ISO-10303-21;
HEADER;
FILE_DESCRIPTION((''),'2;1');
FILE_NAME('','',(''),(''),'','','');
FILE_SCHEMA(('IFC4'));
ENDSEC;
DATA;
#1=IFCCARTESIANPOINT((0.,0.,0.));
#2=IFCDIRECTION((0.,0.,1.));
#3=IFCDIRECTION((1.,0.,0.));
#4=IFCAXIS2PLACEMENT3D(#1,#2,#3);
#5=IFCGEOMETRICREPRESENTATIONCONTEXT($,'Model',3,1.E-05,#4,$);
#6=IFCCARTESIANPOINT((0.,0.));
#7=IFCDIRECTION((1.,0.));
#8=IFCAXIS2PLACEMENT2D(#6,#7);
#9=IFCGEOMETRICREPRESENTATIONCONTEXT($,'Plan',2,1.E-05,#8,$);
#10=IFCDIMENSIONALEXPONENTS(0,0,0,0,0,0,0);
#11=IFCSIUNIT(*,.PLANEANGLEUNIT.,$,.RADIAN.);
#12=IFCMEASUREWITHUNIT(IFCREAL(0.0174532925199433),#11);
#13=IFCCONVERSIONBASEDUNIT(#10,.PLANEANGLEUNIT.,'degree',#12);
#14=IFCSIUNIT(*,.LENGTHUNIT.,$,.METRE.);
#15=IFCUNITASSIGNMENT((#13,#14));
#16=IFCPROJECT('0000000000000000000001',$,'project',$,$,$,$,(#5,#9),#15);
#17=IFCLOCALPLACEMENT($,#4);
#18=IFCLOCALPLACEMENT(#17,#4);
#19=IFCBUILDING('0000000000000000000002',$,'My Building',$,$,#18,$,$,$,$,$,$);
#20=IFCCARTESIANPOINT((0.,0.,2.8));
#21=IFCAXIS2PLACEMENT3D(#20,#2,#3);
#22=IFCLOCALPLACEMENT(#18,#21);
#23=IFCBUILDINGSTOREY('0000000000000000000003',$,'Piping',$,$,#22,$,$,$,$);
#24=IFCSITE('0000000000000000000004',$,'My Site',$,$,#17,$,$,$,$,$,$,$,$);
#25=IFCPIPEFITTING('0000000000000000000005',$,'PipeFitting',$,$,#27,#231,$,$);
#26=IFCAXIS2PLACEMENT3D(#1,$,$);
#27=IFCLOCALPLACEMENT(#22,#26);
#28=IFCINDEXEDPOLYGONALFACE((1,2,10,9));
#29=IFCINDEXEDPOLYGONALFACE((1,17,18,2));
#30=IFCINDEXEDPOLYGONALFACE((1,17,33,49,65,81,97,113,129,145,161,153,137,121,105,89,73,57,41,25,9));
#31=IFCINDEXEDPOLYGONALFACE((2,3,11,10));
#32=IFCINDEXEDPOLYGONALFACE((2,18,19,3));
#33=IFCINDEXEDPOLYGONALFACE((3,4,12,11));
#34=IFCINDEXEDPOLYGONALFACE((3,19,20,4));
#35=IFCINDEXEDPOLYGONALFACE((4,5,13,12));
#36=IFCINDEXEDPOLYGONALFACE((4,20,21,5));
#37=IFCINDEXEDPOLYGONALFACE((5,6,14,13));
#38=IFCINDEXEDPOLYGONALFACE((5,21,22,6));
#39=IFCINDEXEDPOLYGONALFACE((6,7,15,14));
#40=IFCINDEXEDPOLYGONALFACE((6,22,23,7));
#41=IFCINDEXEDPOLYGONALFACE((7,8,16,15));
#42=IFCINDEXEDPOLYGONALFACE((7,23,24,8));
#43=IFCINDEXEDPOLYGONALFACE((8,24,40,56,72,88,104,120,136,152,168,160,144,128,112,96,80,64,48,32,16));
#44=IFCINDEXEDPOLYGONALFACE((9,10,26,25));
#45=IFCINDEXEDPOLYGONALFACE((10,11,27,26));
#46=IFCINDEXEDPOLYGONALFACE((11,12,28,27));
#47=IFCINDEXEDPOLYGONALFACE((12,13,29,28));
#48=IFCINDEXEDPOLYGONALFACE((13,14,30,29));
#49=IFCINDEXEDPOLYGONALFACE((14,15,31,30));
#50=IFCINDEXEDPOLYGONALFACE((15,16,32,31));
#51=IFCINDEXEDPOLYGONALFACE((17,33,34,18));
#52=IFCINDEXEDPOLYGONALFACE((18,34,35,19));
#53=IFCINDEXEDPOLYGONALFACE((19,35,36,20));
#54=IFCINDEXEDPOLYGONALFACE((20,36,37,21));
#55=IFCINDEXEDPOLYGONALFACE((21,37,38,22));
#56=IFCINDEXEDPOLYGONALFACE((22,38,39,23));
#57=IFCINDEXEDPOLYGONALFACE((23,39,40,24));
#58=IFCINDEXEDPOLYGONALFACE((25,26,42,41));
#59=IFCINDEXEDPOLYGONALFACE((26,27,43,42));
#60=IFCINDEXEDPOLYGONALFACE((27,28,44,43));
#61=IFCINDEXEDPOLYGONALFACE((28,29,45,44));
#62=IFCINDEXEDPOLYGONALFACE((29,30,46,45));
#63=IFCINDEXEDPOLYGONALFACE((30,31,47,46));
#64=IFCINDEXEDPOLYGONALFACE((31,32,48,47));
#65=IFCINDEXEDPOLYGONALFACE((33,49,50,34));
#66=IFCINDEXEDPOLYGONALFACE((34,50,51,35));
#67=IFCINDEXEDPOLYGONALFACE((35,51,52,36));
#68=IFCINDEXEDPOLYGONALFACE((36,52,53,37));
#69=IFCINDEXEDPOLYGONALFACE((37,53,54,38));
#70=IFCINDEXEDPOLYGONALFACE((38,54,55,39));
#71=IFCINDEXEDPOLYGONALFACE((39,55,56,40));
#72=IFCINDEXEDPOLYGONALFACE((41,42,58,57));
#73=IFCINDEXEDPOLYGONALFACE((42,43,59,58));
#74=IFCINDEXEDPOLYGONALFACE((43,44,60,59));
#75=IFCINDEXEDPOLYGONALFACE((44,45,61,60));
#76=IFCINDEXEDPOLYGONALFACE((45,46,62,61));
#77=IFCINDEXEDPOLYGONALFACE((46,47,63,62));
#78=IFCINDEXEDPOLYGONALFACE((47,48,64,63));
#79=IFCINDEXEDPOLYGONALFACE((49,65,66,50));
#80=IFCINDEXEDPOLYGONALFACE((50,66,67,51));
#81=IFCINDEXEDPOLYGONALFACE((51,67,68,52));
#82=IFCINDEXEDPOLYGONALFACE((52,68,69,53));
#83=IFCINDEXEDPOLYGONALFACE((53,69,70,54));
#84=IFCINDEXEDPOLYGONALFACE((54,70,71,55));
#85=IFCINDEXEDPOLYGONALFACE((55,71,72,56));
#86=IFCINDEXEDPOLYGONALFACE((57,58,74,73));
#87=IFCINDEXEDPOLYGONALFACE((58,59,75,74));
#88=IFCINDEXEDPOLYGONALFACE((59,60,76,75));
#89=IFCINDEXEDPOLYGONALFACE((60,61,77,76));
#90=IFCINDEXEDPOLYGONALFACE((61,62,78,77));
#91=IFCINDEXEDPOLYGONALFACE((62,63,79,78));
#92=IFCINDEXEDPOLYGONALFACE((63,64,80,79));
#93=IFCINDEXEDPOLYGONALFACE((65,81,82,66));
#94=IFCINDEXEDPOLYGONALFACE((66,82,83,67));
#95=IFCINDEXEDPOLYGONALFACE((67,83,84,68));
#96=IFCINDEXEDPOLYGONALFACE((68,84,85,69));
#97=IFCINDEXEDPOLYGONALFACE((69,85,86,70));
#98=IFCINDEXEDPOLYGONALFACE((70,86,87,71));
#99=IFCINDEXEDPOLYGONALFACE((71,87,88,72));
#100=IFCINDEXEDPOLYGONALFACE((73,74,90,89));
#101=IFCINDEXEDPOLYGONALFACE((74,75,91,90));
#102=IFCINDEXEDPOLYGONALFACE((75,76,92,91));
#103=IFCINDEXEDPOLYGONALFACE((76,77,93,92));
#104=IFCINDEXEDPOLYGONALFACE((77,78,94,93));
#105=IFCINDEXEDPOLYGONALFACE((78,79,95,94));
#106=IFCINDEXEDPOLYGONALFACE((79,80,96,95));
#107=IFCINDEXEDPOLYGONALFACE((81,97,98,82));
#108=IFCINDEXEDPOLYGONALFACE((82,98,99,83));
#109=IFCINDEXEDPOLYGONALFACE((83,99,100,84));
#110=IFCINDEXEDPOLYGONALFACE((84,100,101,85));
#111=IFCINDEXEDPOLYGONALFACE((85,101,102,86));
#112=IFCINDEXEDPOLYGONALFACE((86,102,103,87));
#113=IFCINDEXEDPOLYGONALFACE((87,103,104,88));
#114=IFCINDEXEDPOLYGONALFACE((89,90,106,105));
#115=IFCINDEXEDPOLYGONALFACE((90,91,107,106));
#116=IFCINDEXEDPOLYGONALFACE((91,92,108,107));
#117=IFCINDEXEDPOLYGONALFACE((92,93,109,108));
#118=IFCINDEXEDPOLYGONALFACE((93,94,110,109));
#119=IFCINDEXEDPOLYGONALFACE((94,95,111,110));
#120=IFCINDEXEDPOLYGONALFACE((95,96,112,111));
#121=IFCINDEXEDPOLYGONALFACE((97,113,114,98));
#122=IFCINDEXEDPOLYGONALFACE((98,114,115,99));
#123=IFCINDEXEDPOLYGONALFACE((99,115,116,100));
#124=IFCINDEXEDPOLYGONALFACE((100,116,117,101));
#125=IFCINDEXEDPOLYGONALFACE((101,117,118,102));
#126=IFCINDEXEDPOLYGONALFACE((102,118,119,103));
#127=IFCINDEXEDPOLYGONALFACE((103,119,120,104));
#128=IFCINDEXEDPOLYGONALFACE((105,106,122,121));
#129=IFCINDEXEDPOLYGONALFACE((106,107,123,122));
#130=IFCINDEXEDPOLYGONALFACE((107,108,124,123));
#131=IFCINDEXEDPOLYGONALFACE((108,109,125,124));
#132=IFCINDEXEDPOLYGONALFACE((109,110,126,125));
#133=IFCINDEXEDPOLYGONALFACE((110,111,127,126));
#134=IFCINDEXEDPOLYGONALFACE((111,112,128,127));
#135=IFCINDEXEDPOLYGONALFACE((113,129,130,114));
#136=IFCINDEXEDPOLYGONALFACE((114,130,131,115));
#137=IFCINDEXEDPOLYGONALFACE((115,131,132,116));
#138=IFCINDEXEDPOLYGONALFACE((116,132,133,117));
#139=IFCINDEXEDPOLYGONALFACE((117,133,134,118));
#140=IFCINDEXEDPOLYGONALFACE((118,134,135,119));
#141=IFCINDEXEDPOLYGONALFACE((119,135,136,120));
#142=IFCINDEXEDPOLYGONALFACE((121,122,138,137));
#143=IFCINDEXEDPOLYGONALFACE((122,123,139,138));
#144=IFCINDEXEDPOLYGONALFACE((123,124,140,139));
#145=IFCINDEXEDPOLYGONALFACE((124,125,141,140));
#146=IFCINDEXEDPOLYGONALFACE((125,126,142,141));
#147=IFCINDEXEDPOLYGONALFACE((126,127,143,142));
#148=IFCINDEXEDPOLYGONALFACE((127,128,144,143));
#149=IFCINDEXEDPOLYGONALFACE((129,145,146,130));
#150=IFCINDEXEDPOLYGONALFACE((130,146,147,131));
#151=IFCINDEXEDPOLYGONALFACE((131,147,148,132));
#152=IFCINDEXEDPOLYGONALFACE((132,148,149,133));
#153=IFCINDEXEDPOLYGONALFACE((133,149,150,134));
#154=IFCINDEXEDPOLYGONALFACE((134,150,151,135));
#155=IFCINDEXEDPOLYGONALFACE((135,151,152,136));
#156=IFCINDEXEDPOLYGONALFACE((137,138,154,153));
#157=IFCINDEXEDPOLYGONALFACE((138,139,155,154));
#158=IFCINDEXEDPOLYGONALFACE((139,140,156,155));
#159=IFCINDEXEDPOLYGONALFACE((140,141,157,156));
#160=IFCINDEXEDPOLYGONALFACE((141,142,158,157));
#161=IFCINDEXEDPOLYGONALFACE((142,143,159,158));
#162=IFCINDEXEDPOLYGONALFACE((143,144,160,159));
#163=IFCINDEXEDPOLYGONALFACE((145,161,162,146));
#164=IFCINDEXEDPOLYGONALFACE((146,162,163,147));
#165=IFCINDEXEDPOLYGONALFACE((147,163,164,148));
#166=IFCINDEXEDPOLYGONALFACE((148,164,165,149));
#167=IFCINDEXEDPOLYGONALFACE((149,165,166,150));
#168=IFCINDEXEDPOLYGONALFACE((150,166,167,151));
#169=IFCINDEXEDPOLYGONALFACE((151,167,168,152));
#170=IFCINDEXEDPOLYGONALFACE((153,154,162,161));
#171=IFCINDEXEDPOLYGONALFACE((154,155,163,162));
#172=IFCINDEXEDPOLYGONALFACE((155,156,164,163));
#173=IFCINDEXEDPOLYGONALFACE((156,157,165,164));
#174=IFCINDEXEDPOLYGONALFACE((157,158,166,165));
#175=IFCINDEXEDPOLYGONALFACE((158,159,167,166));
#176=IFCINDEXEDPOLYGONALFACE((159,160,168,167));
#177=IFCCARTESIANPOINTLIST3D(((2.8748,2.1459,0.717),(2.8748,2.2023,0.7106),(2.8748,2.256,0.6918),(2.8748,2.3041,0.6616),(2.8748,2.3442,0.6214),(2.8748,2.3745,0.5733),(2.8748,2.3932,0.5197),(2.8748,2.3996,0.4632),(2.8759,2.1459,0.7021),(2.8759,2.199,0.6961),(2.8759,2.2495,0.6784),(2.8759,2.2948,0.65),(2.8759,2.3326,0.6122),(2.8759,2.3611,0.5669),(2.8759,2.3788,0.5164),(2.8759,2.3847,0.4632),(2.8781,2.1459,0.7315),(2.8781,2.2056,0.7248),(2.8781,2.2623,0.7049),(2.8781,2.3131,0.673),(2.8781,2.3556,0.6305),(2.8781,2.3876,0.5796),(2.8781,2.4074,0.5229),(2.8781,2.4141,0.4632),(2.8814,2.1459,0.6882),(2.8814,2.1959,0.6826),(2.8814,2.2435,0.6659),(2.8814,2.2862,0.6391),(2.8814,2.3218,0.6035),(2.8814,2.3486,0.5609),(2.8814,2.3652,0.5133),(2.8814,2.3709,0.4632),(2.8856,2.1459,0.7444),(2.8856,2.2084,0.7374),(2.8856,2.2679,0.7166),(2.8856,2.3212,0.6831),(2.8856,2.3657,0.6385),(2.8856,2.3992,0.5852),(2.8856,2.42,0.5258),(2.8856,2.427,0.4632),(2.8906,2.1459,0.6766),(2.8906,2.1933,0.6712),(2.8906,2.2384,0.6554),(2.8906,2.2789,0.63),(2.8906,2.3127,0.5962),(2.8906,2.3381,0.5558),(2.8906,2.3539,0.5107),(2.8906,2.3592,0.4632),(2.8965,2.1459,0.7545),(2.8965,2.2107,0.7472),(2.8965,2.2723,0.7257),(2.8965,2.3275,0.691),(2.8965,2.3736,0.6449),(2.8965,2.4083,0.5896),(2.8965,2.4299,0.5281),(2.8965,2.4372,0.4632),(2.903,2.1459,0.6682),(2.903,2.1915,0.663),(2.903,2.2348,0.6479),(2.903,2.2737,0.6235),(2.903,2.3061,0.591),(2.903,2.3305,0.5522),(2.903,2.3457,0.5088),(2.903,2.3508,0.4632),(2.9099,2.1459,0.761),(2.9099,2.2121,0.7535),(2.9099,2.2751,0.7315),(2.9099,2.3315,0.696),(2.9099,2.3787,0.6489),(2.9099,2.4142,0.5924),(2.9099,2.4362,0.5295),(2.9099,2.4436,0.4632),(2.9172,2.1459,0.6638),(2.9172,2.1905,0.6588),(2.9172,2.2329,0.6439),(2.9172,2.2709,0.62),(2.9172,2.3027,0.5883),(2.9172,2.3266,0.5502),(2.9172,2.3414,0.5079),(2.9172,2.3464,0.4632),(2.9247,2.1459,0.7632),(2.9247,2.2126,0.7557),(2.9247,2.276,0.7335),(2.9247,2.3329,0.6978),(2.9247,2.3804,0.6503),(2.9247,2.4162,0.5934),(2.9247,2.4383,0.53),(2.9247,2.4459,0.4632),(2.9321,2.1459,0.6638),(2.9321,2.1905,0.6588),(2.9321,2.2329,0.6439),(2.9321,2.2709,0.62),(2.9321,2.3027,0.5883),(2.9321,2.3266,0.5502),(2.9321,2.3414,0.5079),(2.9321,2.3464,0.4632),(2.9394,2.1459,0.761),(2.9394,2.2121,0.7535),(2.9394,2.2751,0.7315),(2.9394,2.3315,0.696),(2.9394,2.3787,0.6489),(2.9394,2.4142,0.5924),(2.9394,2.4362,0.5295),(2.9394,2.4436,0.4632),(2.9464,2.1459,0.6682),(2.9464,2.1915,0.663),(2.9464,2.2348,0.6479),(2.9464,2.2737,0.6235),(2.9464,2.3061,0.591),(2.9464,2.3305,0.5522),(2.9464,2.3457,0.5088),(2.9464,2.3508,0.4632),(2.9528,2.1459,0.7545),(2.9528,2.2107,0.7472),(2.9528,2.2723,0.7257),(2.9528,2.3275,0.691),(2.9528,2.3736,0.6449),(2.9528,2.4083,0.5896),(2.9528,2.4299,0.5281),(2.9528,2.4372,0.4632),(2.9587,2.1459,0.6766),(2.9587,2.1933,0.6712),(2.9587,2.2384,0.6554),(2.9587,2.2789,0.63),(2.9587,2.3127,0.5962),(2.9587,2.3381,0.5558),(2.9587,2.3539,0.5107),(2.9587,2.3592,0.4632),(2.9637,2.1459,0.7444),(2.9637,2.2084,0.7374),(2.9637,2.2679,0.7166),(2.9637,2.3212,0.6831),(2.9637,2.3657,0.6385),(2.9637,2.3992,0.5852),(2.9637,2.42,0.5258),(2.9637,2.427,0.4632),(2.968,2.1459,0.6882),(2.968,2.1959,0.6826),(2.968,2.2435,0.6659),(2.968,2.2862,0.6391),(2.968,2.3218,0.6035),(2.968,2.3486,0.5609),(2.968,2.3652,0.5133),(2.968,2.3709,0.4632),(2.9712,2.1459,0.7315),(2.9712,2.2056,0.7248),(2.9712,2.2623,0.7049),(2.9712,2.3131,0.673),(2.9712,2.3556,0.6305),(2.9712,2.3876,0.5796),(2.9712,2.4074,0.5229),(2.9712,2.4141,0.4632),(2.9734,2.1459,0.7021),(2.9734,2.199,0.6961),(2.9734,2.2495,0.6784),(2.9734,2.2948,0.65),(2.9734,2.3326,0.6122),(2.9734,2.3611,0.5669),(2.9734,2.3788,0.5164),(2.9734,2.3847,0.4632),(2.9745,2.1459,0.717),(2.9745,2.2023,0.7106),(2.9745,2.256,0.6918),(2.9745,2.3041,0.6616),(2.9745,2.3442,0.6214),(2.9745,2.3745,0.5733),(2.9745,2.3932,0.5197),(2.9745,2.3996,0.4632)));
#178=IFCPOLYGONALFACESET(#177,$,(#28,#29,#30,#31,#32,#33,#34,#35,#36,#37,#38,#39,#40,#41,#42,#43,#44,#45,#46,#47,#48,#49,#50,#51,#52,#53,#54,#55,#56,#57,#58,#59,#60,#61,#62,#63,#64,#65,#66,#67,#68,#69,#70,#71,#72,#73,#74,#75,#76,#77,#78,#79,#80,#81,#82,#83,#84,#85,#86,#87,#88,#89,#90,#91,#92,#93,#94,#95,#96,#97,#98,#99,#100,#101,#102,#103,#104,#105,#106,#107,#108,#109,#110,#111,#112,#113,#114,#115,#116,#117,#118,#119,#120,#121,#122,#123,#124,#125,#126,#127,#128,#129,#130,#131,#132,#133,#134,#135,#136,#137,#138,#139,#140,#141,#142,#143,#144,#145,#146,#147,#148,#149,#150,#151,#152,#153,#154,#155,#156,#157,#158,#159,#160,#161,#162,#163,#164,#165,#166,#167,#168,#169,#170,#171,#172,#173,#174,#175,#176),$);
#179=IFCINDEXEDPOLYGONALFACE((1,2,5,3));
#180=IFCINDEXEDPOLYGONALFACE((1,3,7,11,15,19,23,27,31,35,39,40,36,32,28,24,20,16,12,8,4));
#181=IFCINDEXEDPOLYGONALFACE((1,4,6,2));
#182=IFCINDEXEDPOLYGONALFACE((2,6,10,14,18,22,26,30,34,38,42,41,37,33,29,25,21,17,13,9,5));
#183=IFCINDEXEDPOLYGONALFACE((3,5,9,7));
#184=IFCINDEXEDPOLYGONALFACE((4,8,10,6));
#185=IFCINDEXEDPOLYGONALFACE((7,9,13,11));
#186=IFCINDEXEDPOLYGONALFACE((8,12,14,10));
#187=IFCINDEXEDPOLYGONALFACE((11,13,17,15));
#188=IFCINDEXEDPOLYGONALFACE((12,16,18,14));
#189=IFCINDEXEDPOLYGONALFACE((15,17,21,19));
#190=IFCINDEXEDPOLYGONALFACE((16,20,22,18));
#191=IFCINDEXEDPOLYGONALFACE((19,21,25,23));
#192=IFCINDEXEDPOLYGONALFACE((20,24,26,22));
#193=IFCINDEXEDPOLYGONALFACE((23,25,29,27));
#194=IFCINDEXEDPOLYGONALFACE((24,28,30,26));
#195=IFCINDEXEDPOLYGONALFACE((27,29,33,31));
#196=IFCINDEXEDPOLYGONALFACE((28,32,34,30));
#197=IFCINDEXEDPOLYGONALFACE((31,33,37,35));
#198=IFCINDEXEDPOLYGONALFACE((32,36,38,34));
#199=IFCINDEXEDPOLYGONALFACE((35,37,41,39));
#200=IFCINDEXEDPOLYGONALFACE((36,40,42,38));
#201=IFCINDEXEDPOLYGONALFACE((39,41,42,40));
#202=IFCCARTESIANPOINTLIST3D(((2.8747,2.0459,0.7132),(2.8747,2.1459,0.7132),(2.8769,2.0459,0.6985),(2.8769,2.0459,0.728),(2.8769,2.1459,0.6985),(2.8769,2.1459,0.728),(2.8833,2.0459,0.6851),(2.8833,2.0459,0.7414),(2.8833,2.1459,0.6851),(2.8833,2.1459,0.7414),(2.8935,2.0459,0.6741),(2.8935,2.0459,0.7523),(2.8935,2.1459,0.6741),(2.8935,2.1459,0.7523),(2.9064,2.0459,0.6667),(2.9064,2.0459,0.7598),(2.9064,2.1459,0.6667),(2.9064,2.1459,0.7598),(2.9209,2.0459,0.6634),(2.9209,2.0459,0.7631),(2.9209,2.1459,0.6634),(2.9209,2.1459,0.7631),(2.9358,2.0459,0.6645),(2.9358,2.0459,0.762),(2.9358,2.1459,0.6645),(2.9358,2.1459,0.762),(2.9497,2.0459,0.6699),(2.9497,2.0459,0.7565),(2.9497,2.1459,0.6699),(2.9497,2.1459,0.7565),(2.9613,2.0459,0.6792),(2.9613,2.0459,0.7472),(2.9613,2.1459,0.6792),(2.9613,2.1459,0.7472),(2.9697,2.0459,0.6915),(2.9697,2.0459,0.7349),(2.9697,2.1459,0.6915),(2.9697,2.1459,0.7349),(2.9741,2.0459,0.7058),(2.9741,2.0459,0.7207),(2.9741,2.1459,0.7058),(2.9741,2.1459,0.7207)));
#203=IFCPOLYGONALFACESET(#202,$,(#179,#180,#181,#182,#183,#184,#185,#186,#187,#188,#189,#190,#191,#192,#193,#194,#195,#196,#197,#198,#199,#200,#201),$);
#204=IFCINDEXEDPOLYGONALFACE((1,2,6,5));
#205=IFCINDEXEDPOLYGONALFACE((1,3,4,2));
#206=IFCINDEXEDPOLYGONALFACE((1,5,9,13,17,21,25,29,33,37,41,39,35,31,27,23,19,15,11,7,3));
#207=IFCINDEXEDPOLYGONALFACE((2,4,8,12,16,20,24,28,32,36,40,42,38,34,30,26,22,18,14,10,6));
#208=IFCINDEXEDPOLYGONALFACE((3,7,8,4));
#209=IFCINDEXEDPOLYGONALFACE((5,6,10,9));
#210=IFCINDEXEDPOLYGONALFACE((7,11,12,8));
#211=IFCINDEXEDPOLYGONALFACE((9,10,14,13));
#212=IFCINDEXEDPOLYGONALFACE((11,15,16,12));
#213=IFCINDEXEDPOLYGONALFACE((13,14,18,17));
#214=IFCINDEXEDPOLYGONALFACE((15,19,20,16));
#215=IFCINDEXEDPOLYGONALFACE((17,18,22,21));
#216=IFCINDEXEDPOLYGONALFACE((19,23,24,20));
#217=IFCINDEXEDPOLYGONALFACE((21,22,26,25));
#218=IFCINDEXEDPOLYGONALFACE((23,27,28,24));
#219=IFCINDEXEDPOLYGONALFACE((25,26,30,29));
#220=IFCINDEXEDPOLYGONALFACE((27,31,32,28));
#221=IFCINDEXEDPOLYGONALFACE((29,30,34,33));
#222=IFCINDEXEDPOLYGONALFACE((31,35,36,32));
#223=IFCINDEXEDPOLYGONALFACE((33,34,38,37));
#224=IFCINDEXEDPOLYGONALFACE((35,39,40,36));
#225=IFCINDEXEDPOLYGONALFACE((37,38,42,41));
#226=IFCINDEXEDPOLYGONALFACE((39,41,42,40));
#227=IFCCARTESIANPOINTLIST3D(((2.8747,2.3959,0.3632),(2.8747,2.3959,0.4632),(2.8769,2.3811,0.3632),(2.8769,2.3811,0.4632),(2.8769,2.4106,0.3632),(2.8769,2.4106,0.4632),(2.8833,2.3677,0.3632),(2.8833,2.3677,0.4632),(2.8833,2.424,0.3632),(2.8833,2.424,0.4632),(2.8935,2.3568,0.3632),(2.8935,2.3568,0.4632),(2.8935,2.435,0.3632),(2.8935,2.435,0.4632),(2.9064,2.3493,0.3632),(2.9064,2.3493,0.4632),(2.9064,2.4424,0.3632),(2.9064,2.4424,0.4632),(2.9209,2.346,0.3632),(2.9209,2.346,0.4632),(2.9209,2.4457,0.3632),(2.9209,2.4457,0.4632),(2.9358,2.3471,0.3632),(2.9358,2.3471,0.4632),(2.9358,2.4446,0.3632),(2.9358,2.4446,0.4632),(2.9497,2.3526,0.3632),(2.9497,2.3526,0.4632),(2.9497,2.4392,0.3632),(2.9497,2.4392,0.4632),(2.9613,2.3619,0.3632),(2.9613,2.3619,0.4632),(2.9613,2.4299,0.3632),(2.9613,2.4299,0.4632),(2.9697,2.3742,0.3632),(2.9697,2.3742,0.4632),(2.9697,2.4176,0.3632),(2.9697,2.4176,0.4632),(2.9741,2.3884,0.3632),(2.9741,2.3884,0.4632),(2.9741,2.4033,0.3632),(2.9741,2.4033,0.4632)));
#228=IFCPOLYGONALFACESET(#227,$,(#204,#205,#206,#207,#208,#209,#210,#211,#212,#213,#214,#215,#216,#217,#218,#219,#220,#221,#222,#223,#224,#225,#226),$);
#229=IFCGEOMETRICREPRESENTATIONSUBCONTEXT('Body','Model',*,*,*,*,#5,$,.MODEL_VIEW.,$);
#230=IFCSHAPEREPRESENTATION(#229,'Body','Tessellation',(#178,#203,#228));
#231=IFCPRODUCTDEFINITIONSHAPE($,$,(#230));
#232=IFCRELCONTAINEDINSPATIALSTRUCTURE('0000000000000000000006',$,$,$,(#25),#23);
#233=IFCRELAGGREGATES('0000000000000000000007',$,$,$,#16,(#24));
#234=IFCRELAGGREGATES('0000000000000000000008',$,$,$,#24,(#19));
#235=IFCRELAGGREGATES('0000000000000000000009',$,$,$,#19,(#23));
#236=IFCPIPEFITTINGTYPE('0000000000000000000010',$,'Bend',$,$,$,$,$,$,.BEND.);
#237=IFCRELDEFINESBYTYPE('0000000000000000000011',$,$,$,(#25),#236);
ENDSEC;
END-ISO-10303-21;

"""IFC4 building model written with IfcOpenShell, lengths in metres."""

from ifc_helpers import new_model, entity, si_unit, converted_unit, frame, origin_with_axes, origin_2d_with_axis, place, context, subcontext, project, spatial, circle, extrude, source, transform, mapped, type_object, type_shapes, element, save


model = new_model("IFC4")

# Units and contexts
model_context = context("Model", 3, precision=1e-05, world=origin_with_axes())
plan_context = context("Plan", 2, precision=1e-05, world=origin_2d_with_axis())
body_context = subcontext(model_context, "Body", "Model", "MODEL_VIEW")
ifc_project = project(units=[converted_unit("PLANEANGLEUNIT", "degree", entity("IfcReal", 0.0174532925199433), si_unit("PLANEANGLEUNIT", "RADIAN"), dimensions=[0, 0, 0, 0, 0, 0, 0]), si_unit("LENGTHUNIT", "METRE")], contexts=[model_context, plan_context])

# Site, building, storey
site_placement = place(None, origin_with_axes())
site = spatial("IfcSite", under=ifc_project, at=site_placement, Name="My Site")
building_placement = place(site_placement, origin_with_axes())
building = spatial("IfcBuilding", under=site, at=building_placement, Name="My Building")
storey_placement = place(building_placement, frame((0.0, 0.0, 2.8), z_axis=(0.0, 0.0, 1.0), x_axis=(1.0, 0.0, 0.0)))
storey = spatial("IfcBuildingStorey", under=building, at=storey_placement, Name="Piping")

# Pipe fitting
pipe_fitting_type_1 = type_object("IfcPipeFittingType", Name="Bend", PredefinedType="BEND")
shared_shape = source(origin_with_axes(), body_context, "Body", "SolidModel", [
    entity("IfcSweptDiskSolid", entity("IfcIndexedPolyCurve", entity("IfcCartesianPointList3D", [[0.0, 0.0, 0.1], [0.0, -0.0732, 0.2768], [0.0, -0.25, 0.35]]), [entity("IfcArcIndex", [1, 2, 3])]), 0.05),
    extrude(circle(Radius=0.05), origin_with_axes(), (0.0, 0.0, 1.0), 0.1),
    extrude(circle(Radius=0.05), frame((0.0, -0.25, 0.35), z_axis=(0.0, -1.0, 0.0), x_axis=(1.0, 0.0, 0.0)), (0.0, 0.0, 1.0), 0.1),
])
type_shapes(pipe_fitting_type_1, [shared_shape])
for number, where, z_axis, x_axis, name in (
    (1, (2.9247, 2.0459, 0.7132), (0.0, 1.0, 0.0), (-1.0, 0.0, 0.0), "PipeFitting"),
):
    element("IfcPipeFitting", number, at=place(storey_placement, frame(where, z_axis=z_axis, x_axis=x_axis)), inside=storey, type_object=pipe_fitting_type_1, Name=name, context=body_context, shape_type="MappedRepresentation", body=[
        mapped(shared_shape, transform((0.0, 0.0, 0.0), x_axis=(1.0, 0.0, 0.0), y_axis=(0.0, 1.0, 0.0), z_axis=(0.0, 0.0, 1.0), scale=1.0)),
    ])

save(model, "model.ifc")
